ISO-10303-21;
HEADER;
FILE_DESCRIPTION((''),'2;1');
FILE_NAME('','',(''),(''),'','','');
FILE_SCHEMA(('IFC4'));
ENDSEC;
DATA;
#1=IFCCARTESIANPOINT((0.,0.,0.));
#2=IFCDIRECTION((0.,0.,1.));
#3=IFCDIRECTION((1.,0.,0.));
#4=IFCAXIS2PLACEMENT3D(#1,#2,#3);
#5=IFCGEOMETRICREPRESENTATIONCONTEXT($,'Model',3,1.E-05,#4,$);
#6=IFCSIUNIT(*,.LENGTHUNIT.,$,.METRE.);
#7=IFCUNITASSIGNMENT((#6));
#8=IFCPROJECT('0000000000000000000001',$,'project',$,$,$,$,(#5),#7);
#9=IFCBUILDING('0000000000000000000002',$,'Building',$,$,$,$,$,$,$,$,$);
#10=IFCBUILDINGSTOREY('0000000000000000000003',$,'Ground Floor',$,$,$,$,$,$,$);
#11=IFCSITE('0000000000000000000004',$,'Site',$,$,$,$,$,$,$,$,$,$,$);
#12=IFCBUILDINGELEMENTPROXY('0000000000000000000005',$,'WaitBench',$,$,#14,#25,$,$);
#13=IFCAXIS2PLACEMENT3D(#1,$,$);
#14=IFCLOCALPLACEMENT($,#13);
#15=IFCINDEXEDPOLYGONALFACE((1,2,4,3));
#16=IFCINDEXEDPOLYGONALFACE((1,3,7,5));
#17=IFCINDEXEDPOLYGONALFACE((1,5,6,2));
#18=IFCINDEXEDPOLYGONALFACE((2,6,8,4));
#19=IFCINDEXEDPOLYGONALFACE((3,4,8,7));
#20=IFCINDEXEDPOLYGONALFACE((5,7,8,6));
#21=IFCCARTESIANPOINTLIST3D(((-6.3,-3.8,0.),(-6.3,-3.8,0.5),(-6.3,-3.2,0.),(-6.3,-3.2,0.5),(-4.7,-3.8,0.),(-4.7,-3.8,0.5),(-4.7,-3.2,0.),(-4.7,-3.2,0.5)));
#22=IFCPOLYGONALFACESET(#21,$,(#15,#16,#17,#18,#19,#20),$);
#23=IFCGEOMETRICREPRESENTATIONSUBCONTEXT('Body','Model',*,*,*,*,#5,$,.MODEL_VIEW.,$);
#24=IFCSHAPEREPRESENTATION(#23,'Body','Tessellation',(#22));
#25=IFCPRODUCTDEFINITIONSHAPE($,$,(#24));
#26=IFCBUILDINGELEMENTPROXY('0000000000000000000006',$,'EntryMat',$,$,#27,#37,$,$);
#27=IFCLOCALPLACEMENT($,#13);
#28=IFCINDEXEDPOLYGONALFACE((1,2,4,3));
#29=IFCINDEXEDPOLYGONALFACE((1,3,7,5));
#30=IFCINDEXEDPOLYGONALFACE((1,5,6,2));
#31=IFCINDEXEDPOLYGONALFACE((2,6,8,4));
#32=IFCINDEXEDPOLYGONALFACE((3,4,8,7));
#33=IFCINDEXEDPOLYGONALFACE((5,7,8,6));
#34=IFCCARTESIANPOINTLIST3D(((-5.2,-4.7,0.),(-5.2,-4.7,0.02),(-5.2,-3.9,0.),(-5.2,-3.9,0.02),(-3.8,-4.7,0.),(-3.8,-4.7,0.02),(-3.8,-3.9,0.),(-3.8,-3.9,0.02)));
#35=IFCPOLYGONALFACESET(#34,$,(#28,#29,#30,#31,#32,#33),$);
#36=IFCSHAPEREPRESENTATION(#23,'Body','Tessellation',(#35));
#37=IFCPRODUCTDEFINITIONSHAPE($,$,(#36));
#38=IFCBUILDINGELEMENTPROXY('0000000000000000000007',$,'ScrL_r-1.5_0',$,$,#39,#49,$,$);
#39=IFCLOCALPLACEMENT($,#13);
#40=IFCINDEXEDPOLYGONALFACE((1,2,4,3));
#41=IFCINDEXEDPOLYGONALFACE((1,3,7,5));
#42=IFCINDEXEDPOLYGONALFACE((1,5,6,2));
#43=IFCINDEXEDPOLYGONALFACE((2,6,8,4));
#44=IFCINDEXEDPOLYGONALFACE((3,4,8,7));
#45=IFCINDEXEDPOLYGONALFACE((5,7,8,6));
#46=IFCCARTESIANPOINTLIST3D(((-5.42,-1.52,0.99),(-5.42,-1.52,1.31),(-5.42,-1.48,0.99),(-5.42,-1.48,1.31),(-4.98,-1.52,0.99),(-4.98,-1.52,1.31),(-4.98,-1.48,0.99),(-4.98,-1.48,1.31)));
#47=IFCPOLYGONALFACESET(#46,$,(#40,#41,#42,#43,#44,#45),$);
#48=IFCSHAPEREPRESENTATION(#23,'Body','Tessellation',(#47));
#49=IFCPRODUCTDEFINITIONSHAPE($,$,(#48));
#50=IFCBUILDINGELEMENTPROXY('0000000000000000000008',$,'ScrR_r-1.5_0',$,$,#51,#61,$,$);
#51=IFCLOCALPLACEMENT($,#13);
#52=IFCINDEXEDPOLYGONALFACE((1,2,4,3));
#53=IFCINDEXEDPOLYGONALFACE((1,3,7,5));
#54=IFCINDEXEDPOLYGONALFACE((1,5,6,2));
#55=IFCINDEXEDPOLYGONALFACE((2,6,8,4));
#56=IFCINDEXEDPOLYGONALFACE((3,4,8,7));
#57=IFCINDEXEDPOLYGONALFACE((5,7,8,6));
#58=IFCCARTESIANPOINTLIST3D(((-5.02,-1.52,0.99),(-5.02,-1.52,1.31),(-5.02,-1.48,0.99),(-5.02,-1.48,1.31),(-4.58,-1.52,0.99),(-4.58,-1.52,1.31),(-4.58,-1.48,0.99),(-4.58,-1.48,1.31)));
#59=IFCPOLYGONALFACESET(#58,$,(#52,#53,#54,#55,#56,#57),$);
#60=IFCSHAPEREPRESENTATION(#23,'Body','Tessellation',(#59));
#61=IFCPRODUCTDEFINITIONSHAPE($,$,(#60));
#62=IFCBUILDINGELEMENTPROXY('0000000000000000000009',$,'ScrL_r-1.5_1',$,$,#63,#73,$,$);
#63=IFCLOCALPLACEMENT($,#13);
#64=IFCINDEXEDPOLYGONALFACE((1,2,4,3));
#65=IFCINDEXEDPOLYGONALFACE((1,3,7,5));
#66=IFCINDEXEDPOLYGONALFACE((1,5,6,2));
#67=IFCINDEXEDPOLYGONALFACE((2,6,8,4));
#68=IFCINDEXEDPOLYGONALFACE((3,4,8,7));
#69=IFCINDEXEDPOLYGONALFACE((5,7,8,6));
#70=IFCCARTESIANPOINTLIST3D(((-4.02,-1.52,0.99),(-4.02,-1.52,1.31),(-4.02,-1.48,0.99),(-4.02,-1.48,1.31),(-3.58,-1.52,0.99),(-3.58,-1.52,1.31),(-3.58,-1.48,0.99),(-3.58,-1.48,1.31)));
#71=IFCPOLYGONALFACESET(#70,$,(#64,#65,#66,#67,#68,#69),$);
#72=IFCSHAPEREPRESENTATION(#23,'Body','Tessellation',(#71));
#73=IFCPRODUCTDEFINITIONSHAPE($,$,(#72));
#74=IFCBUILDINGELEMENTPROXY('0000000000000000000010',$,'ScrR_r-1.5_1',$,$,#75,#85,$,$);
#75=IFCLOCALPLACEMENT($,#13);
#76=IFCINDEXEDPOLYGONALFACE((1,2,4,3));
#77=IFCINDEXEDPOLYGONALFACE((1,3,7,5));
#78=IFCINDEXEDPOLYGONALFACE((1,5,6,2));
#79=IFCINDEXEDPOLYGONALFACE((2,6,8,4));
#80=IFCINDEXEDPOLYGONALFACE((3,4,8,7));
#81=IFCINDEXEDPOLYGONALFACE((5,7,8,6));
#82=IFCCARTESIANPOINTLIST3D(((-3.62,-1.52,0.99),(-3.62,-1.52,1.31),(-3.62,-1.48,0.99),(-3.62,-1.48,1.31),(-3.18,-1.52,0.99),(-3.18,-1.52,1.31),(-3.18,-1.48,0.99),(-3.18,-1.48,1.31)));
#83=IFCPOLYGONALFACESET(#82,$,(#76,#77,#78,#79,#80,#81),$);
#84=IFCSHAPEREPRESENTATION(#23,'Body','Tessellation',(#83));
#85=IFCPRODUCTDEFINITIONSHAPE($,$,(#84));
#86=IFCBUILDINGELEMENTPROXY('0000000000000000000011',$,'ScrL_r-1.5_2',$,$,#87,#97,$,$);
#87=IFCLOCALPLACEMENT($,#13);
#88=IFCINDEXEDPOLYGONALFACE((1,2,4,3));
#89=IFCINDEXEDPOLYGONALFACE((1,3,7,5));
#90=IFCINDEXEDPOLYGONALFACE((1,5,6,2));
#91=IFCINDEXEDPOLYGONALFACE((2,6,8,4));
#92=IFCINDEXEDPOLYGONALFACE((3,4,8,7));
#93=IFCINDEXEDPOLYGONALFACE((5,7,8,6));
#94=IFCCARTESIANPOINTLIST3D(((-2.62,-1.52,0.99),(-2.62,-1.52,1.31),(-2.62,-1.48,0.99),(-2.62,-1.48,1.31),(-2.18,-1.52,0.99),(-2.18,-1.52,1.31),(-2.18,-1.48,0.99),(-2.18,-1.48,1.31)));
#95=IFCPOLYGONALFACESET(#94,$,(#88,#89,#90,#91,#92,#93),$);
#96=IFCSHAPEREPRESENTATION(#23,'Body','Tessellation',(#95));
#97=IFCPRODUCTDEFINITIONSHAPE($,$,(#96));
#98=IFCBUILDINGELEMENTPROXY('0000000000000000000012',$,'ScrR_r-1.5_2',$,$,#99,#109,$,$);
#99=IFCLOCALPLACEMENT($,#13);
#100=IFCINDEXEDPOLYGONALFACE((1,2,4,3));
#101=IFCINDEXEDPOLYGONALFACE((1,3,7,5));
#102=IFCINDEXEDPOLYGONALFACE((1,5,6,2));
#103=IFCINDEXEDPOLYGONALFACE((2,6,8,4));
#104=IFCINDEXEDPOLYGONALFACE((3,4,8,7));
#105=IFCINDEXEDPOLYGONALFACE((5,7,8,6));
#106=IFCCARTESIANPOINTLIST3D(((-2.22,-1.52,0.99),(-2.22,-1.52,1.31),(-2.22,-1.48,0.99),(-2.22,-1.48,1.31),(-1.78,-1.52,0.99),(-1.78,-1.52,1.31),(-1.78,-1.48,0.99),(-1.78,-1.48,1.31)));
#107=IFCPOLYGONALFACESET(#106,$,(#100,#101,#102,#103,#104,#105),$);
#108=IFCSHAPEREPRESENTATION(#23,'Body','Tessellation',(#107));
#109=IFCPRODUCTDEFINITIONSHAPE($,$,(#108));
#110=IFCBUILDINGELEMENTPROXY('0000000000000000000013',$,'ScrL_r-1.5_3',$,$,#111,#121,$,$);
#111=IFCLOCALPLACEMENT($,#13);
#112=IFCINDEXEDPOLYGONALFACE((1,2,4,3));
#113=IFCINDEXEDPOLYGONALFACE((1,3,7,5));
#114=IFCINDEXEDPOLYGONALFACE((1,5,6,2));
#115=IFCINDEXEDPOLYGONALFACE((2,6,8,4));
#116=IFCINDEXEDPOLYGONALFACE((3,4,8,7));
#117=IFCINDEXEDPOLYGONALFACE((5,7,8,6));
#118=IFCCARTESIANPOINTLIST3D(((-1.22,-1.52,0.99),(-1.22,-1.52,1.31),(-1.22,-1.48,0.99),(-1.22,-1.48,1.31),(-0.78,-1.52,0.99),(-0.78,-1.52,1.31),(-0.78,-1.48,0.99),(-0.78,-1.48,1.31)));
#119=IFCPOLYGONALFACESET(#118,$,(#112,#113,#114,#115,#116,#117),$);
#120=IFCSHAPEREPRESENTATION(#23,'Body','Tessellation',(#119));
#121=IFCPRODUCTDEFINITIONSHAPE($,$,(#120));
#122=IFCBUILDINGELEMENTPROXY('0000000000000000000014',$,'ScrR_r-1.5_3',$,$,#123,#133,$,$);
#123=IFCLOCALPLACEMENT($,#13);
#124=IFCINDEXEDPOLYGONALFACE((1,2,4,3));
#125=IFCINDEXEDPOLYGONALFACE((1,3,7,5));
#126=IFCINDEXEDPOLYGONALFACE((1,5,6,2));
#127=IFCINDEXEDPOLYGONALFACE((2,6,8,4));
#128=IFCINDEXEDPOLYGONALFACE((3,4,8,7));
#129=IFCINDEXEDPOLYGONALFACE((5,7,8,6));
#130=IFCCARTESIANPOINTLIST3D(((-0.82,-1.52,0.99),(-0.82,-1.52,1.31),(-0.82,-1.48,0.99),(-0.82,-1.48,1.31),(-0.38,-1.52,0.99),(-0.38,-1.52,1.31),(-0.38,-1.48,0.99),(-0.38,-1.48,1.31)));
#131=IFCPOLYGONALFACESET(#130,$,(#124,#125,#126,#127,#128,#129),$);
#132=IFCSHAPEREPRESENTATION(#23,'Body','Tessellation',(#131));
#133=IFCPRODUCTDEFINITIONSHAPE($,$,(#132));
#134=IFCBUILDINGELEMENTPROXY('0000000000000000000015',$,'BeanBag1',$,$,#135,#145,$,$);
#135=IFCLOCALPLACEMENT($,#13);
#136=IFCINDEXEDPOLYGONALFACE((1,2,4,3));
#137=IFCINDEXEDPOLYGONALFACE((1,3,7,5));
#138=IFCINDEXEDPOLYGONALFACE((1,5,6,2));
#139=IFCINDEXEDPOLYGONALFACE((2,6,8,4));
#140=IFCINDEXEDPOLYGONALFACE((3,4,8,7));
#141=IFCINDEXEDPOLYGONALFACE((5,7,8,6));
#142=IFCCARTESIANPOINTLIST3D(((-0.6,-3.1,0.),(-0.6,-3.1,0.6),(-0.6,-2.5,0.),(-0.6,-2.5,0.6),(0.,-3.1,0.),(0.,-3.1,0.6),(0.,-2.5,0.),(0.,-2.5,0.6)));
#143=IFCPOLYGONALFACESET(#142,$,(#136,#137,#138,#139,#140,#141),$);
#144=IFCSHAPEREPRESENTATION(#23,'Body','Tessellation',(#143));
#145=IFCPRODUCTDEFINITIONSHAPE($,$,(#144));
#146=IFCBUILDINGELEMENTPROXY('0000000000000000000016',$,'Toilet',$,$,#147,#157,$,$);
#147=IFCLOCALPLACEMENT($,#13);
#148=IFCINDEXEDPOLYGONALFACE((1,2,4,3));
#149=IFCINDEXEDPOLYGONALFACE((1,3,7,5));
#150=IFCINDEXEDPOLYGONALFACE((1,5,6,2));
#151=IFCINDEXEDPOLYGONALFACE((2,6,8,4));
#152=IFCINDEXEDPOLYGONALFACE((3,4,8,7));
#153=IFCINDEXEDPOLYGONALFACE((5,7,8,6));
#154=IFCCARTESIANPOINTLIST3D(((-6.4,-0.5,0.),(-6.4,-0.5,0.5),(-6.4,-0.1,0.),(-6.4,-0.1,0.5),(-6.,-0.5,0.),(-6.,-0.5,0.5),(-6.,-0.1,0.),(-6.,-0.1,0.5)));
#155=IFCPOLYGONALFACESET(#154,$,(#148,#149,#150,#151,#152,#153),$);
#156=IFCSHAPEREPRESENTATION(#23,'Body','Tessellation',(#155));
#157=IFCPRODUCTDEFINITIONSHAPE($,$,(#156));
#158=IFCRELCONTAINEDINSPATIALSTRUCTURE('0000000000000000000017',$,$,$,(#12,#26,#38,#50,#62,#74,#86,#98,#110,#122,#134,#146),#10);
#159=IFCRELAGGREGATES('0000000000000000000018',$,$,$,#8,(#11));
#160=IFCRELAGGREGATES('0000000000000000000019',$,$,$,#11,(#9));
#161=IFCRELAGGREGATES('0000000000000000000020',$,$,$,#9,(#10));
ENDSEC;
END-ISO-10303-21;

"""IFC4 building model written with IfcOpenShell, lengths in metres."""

from ifc_helpers import new_model, si_unit, frame, origin_with_axes, origin_2d, place, context, subcontext, project, spatial, rectangle, extrude, element, save


model = new_model("IFC4")

# Units and contexts
model_context = context("Model", 3, precision=1e-05, world=origin_with_axes())
body_context = subcontext(model_context, "Body", "Model", "MODEL_VIEW")
ifc_project = project(units=[si_unit("LENGTHUNIT", "METRE")], contexts=[model_context])

# Site, building, storey
site = spatial("IfcSite", under=ifc_project, Name="Site")
building = spatial("IfcBuilding", under=site, Name="Building")
storey = spatial("IfcBuildingStorey", under=building, Name="Ground Floor")

# Building element proxies
proxy_1_placement = place(None, frame((-5.5, -3.5, 0.25), z_axis=(0.0, 0.0, 1.0), x_axis=(1.0, 0.0, 0.0)))
element("IfcBuildingElementProxy", 1, at=proxy_1_placement, inside=storey, Name="WaitBench", context=body_context, shape_type="SweptSolid", body=[
    extrude(rectangle(XDim=1.6, YDim=0.6, at=origin_2d()), frame((0.0, 0.0, -0.25)), (0.0, 0.0, 1.0), 0.5),
])
proxy_2_placement = place(None, frame((-4.5, -4.3, 0.01), z_axis=(0.0, 0.0, 1.0), x_axis=(1.0, 0.0, 0.0)))
element("IfcBuildingElementProxy", 2, at=proxy_2_placement, inside=storey, Name="EntryMat", context=body_context, shape_type="SweptSolid", body=[
    extrude(rectangle(XDim=1.4, YDim=0.8, at=origin_2d()), frame((0.0, 0.0, -0.01)), (0.0, 0.0, 1.0), 0.02),
])
for number, where, z_axis, x_axis, name in (
    (3, (-5.2, -1.5, 1.15), (0.0, 0.0, 1.0), (1.0, 0.0, 0.0), "ScrL_r-1.5_0"),
    (4, (-4.8, -1.5, 1.15), (0.0, 0.0, 1.0), (1.0, 0.0, 0.0), "ScrR_r-1.5_0"),
    (5, (-3.8, -1.5, 1.15), (0.0, 0.0, 1.0), (1.0, 0.0, 0.0), "ScrL_r-1.5_1"),
    (6, (-3.4, -1.5, 1.15), (0.0, 0.0, 1.0), (1.0, 0.0, 0.0), "ScrR_r-1.5_1"),
    (7, (-2.4, -1.5, 1.15), (0.0, 0.0, 1.0), (1.0, 0.0, 0.0), "ScrL_r-1.5_2"),
    (8, (-2.0, -1.5, 1.15), (0.0, 0.0, 1.0), (1.0, 0.0, 0.0), "ScrR_r-1.5_2"),
    (9, (-1.0, -1.5, 1.15), (0.0, 0.0, 1.0), (1.0, 0.0, 0.0), "ScrL_r-1.5_3"),
    (10, (-0.6, -1.5, 1.15), (0.0, 0.0, 1.0), (1.0, 0.0, 0.0), "ScrR_r-1.5_3"),
):
    element("IfcBuildingElementProxy", number, at=place(None, frame(where, z_axis=z_axis, x_axis=x_axis)), inside=storey, Name=name, context=body_context, shape_type="SweptSolid", body=[
        extrude(rectangle(XDim=0.44, YDim=0.04, at=origin_2d()), frame((0.0, 0.0, -0.16)), (0.0, 0.0, 1.0), 0.32),
    ])
proxy_3_placement = place(None, frame((-0.3, -2.8, 0.3), z_axis=(0.0, 0.0, 1.0), x_axis=(1.0, 0.0, 0.0)))
element("IfcBuildingElementProxy", 11, at=proxy_3_placement, inside=storey, Name="BeanBag1", context=body_context, shape_type="SweptSolid", body=[
    extrude(rectangle(XDim=0.6, YDim=0.6, at=origin_2d()), frame((0.0, 0.0, -0.3)), (0.0, 0.0, 1.0), 0.6),
])
proxy_4_placement = place(None, frame((-6.2, -0.3, 0.25), z_axis=(0.0, 0.0, 1.0), x_axis=(1.0, 0.0, 0.0)))
element("IfcBuildingElementProxy", 12, at=proxy_4_placement, inside=storey, Name="Toilet", context=body_context, shape_type="SweptSolid", body=[
    extrude(rectangle(XDim=0.4, YDim=0.4, at=origin_2d()), frame((0.0, 0.0, -0.25)), (0.0, 0.0, 1.0), 0.5),
])

save(model, "model.ifc")
